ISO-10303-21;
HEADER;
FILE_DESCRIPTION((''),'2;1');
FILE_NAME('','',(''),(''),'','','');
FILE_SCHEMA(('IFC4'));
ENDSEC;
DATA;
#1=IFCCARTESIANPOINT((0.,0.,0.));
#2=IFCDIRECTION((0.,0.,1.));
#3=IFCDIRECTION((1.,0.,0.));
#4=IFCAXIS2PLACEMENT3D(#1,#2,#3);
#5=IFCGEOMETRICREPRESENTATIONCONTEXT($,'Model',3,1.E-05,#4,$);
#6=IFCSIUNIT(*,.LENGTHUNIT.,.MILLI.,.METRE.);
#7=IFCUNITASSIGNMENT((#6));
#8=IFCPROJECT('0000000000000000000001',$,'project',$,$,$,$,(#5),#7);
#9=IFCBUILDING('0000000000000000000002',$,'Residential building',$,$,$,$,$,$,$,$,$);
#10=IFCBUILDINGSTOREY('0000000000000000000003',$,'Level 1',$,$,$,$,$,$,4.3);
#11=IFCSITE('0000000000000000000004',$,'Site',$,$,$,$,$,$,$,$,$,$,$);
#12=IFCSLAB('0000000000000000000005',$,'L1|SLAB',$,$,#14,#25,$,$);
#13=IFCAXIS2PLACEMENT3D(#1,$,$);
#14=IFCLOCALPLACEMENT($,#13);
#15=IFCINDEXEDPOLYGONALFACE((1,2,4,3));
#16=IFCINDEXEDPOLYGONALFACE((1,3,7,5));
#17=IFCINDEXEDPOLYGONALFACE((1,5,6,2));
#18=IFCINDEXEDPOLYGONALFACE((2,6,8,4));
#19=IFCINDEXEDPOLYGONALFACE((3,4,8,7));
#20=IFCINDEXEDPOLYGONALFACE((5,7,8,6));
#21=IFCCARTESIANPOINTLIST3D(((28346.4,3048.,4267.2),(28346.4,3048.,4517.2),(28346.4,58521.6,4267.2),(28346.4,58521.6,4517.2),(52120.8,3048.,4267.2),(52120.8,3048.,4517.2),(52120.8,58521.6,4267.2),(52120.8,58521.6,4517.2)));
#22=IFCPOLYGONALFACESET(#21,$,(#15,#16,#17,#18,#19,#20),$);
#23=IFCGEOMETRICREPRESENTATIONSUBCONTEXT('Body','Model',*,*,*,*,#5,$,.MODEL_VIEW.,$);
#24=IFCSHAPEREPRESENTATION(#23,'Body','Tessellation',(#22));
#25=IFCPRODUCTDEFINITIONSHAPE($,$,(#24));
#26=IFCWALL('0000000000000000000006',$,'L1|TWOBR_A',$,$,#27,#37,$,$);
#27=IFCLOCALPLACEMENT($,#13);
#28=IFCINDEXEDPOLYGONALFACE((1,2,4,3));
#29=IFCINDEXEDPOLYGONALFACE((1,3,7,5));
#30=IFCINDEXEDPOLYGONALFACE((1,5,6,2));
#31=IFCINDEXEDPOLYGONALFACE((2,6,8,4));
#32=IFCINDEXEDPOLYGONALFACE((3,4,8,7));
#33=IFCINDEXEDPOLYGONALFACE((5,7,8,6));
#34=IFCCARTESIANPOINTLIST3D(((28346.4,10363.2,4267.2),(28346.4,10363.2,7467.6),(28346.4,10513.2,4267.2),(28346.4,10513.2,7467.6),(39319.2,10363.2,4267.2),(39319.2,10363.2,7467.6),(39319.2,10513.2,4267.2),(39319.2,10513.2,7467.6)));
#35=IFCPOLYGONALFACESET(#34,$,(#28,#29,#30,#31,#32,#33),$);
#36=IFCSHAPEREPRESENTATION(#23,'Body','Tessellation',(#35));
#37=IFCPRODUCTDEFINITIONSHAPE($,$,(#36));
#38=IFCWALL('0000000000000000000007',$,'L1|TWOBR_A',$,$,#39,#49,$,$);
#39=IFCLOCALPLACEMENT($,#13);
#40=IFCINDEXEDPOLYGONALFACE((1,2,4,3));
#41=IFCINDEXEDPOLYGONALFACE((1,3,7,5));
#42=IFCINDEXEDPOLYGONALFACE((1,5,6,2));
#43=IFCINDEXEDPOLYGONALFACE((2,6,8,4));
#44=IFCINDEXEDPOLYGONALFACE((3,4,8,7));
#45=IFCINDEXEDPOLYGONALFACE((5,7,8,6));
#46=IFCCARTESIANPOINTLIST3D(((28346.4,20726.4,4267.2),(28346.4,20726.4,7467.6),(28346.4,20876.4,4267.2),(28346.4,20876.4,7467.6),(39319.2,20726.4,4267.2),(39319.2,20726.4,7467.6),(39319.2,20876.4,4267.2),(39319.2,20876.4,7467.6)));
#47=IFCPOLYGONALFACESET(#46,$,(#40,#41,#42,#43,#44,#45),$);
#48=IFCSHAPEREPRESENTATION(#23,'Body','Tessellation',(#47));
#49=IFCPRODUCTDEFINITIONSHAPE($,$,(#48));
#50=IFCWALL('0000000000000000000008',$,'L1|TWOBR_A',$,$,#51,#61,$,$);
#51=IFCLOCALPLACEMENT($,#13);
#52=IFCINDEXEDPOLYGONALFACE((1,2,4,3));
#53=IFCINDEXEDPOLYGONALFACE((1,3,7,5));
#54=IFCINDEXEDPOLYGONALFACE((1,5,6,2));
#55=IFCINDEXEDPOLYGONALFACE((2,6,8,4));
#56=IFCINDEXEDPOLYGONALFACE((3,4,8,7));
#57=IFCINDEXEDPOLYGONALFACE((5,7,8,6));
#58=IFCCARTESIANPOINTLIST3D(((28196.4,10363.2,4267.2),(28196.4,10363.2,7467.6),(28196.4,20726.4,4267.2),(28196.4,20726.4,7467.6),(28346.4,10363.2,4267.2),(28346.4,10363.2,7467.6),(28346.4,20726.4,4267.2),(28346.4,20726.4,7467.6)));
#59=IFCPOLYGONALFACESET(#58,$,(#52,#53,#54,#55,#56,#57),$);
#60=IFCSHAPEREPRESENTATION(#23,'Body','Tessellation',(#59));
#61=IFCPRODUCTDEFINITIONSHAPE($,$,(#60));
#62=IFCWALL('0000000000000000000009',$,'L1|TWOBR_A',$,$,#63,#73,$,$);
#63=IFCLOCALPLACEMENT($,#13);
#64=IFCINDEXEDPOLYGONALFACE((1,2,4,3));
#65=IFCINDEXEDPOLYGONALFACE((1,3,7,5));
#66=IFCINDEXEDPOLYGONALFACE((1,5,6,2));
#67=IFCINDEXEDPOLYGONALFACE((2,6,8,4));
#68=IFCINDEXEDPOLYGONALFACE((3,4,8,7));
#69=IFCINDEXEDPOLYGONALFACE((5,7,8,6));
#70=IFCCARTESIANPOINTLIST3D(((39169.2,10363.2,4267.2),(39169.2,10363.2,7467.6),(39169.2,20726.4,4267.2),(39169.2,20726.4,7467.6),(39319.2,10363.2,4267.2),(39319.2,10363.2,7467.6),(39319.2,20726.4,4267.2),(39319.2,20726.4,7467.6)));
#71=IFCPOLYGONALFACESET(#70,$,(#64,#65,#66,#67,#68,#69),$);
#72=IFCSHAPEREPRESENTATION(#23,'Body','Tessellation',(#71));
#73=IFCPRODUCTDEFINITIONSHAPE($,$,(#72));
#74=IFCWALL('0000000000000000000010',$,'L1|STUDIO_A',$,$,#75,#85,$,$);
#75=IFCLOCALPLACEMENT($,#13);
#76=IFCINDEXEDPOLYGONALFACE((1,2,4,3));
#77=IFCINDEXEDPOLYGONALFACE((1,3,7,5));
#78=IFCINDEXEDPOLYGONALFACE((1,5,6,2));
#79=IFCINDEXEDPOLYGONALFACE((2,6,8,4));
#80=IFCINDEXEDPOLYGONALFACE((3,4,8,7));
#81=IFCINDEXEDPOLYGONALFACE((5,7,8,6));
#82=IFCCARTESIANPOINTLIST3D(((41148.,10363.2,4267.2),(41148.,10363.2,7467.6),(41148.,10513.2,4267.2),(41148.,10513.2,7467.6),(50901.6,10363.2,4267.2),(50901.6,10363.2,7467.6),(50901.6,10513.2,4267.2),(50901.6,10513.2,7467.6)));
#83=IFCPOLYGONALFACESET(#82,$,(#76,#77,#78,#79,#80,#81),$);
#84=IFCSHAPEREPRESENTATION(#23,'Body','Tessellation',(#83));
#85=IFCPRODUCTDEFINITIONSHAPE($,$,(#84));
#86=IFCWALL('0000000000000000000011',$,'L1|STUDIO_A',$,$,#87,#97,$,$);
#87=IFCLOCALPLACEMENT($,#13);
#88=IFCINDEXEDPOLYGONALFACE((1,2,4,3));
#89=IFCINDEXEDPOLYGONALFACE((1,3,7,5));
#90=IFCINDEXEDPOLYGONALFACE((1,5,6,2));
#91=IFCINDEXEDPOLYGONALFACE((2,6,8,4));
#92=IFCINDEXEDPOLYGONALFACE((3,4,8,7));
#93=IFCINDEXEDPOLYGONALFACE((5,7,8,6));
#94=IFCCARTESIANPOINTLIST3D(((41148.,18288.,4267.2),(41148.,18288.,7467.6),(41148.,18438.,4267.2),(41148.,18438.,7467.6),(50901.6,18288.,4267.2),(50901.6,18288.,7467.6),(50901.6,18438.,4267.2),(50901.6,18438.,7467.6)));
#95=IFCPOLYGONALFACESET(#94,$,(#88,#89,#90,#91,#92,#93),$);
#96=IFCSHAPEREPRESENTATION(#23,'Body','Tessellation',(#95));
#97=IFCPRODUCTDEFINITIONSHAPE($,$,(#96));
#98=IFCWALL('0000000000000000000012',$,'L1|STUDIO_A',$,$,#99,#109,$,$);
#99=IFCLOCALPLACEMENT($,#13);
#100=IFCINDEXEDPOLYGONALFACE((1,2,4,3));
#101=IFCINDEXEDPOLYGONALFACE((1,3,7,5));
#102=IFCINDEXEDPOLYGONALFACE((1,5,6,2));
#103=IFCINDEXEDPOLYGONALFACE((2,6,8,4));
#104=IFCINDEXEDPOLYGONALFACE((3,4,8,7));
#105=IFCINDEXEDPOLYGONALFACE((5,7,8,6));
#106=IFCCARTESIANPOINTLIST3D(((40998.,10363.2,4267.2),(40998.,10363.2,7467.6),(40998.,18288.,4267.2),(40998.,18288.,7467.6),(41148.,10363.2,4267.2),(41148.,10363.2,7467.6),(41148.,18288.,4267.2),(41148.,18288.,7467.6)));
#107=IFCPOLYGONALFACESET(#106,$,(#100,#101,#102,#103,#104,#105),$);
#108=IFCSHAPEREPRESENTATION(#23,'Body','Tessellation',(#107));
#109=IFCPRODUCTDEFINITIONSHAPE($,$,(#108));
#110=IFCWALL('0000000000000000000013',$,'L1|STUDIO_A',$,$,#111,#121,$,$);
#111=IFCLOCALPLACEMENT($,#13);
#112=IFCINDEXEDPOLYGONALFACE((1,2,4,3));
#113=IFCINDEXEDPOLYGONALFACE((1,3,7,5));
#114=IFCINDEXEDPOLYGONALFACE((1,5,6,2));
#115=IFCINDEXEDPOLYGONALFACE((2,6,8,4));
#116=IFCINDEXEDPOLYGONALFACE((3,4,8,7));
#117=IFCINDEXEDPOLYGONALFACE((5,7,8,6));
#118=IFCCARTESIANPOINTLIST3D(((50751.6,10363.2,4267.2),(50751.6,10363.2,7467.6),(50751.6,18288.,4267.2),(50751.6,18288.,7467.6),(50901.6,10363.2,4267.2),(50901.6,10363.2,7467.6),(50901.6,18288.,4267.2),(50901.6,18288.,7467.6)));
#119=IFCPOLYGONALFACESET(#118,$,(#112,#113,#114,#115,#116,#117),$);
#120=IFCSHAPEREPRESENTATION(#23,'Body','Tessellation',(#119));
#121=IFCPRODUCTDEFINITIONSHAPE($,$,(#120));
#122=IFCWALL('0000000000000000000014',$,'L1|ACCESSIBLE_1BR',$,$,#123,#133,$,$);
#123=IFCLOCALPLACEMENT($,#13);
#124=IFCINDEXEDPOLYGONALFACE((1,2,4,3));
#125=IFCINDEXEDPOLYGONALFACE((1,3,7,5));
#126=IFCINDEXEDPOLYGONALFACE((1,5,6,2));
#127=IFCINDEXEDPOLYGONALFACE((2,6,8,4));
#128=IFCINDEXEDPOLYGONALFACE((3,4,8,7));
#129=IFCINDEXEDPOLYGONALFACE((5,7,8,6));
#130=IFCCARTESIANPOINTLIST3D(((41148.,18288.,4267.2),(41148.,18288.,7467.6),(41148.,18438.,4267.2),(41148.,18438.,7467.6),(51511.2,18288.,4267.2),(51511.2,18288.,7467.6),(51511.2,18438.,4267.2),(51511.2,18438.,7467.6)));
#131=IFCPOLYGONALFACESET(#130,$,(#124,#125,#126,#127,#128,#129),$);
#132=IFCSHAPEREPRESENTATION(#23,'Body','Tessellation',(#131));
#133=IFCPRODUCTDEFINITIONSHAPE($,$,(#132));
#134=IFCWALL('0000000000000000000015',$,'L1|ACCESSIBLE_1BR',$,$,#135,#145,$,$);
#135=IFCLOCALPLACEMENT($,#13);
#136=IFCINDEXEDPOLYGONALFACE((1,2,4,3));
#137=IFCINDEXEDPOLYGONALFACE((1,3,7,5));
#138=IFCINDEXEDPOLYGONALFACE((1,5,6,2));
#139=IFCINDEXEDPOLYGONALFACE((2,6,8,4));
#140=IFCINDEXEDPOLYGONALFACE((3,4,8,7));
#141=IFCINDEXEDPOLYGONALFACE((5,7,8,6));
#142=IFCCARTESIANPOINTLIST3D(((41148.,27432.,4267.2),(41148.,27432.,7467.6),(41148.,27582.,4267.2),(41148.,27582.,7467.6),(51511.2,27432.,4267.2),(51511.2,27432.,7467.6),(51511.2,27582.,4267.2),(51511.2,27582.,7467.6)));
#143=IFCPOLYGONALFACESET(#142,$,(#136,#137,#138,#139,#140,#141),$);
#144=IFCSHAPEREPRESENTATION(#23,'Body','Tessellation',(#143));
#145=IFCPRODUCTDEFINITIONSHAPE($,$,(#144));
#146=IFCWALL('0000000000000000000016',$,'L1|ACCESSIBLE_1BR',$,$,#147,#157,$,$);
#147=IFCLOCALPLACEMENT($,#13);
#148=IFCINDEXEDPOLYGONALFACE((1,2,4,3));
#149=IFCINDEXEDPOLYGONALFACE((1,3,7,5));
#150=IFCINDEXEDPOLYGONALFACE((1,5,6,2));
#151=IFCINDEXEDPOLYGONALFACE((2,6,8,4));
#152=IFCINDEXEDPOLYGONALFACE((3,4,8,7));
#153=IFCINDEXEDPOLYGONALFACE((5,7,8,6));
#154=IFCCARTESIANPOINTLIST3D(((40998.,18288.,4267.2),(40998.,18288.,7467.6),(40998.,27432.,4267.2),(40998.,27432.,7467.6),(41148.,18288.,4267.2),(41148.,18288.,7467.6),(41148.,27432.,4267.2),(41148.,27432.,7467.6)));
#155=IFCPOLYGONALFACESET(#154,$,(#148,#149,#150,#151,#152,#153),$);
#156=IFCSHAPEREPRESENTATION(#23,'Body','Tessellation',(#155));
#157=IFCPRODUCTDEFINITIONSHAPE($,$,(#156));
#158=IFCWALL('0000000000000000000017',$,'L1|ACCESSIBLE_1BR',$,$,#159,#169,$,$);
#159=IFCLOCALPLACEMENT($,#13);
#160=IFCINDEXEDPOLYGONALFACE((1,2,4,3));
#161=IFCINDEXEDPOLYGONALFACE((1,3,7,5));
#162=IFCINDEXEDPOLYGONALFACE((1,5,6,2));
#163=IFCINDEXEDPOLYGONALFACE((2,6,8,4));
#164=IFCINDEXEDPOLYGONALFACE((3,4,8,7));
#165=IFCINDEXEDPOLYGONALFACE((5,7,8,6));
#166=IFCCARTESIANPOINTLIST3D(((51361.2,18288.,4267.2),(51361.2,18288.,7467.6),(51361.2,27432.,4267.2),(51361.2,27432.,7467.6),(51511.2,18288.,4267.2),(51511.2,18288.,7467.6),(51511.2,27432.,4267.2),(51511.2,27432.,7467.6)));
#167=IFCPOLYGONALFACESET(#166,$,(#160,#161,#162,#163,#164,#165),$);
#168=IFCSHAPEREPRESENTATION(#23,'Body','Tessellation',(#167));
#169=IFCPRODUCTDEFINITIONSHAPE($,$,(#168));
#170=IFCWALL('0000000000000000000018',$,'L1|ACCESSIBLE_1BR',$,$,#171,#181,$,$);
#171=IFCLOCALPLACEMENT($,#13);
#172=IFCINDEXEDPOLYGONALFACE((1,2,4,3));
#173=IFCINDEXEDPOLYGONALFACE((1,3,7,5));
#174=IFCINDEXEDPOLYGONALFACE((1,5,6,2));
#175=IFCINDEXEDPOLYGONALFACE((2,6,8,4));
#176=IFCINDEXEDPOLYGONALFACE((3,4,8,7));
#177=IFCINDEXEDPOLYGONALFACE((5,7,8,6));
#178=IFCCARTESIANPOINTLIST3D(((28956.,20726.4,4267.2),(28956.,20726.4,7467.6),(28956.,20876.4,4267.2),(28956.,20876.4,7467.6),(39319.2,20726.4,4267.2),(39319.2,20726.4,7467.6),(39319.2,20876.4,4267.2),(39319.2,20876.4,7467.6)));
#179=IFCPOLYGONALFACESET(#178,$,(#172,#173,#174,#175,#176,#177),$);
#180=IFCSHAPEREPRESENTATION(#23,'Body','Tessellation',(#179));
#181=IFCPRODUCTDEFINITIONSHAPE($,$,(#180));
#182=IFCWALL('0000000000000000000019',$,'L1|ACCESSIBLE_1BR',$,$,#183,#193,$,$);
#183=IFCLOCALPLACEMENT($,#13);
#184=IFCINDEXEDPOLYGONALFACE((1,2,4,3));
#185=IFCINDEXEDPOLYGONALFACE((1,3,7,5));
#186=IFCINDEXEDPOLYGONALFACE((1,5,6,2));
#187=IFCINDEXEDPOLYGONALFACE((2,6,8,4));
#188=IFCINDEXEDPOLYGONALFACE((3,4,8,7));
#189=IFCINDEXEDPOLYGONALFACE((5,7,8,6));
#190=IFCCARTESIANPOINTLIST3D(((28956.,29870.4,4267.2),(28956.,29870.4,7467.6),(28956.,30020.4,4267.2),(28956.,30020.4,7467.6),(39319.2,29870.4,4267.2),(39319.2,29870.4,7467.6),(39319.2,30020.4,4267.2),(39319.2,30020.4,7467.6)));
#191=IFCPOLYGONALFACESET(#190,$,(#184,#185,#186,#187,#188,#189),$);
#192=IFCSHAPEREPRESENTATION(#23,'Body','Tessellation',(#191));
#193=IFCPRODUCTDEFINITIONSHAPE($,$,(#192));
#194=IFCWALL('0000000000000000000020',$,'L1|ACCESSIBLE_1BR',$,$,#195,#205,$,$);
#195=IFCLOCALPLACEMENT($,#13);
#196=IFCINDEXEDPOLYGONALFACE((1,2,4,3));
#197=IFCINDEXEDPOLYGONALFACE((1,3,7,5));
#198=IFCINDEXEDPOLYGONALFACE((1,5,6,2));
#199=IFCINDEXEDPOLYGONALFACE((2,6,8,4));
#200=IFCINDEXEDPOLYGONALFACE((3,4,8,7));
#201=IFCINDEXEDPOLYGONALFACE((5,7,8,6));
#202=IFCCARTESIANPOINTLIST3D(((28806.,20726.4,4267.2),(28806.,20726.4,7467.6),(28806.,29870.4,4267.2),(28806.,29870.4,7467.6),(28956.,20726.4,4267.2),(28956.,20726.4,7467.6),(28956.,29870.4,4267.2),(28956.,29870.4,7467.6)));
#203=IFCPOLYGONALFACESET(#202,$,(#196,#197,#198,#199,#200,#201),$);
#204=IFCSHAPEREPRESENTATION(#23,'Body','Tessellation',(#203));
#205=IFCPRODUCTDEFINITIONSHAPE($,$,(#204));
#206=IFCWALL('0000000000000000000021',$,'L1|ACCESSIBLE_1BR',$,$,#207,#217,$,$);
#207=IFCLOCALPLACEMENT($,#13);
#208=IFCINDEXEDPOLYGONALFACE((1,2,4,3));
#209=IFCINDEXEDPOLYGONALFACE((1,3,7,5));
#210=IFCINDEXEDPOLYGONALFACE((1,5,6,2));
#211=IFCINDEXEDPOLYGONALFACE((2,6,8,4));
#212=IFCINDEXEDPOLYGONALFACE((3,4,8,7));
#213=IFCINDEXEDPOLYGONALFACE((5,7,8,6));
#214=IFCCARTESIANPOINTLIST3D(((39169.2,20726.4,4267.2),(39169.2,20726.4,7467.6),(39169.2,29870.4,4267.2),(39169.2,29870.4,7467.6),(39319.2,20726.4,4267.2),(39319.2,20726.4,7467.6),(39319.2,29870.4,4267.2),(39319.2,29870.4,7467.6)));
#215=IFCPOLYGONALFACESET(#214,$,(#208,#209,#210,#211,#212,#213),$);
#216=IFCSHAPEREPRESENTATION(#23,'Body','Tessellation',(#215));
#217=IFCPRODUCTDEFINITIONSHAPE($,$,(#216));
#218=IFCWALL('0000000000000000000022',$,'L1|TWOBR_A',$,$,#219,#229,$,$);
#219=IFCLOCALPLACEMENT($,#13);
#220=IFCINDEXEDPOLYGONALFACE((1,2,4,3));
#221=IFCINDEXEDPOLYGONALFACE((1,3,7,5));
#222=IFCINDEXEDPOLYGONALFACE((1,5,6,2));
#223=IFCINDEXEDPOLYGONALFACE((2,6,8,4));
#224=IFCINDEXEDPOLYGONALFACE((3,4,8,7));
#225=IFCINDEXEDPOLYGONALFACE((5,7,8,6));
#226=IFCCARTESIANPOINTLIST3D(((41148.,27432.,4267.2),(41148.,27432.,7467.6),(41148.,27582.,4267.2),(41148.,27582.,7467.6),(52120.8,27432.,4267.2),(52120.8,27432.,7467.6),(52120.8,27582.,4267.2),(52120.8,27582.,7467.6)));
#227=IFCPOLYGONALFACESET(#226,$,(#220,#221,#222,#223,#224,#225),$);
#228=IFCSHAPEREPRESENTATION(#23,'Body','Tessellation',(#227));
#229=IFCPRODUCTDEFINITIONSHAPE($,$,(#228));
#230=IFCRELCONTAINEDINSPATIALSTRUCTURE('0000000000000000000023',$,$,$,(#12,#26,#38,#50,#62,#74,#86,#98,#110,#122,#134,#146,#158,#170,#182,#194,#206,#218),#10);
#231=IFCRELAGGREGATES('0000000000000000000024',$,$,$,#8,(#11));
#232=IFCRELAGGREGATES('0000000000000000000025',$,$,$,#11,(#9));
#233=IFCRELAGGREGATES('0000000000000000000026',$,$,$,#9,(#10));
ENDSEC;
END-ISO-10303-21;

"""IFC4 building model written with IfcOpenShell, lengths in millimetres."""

from ifc_helpers import new_model, si_unit, frame, origin_with_axes, place, context, subcontext, project, spatial, indexed_curve, outline, extrude, element, save


model = new_model("IFC4")

# Units and contexts
model_context = context("Model", 3, precision=1e-05, world=origin_with_axes())
body_context = subcontext(model_context, "Body", "Model", "MODEL_VIEW")
ifc_project = project(units=[si_unit("LENGTHUNIT", "METRE", prefix="MILLI")], contexts=[model_context])

# Site, building, storey
site = spatial("IfcSite", under=ifc_project, Name="Site")
building = spatial("IfcBuilding", under=site, Name="Residential building")
storey = spatial("IfcBuildingStorey", under=building, Name="Level 1", Elevation=4.3)

# Slab
slab_placement = place(None, frame((28346.4, 3048.0, 4267.2), z_axis=(0.0, 0.0, 1.0), x_axis=(1.0, 0.0, 0.0)))
element("IfcSlab", 1, at=slab_placement, inside=storey, Name="L1|SLAB", context=body_context, shape_type="SweptSolid", body=[
    extrude(outline(indexed_curve([(0.0, 0.0), (23774.4, 0.0), (23774.4, 55473.6), (0.0, 55473.6), (0.0, 0.0)])), None, (0.0, 0.0, 1.0), 250.0),
])

# Walls
for number, where, z_axis, x_axis, name in (
    (2, (28346.4, 10363.2, 4267.2), (0.0, 0.0, 1.0), (1.0, 0.0, 0.0), "L1|TWOBR_A"),
    (3, (28346.4, 20726.4, 4267.2), (0.0, 0.0, 1.0), (1.0, 0.0, 0.0), "L1|TWOBR_A"),
):
    element("IfcWall", number, at=place(None, frame(where, z_axis=z_axis, x_axis=x_axis)), inside=storey, Name=name, context=body_context, shape_type="SweptSolid", body=[
        extrude(outline(indexed_curve([(0.0, 0.0), (0.0, 150.0), (10972.8, 150.0), (10972.8, 0.0), (0.0, 0.0)], self_intersect=False)), origin_with_axes(), (0.0, 0.0, 1.0), 3200.4),
    ])
for number, where, z_axis, x_axis, name in (
    (4, (28346.4, 10363.2, 4267.2), (0.0, 0.0, 1.0), (0.0, 1.0, 0.0), "L1|TWOBR_A"),
    (5, (39319.2, 10363.2, 4267.2), (0.0, 0.0, 1.0), (0.0, 1.0, 0.0), "L1|TWOBR_A"),
):
    element("IfcWall", number, at=place(None, frame(where, z_axis=z_axis, x_axis=x_axis)), inside=storey, Name=name, context=body_context, shape_type="SweptSolid", body=[
        extrude(outline(indexed_curve([(0.0, 0.0), (0.0, 150.0), (10363.2, 150.0), (10363.2, 0.0), (0.0, 0.0)], self_intersect=False)), origin_with_axes(), (0.0, 0.0, 1.0), 3200.4),
    ])
for number, where, z_axis, x_axis, name in (
    (6, (41148.0, 10363.2, 4267.2), (0.0, 0.0, 1.0), (1.0, 0.0, 0.0), "L1|STUDIO_A"),
    (7, (41148.0, 18288.0, 4267.2), (0.0, 0.0, 1.0), (1.0, 0.0, 0.0), "L1|STUDIO_A"),
):
    element("IfcWall", number, at=place(None, frame(where, z_axis=z_axis, x_axis=x_axis)), inside=storey, Name=name, context=body_context, shape_type="SweptSolid", body=[
        extrude(outline(indexed_curve([(0.0, 0.0), (0.0, 150.0), (9753.6, 150.0), (9753.6, 0.0), (0.0, 0.0)], self_intersect=False)), origin_with_axes(), (0.0, 0.0, 1.0), 3200.4),
    ])
for number, where, z_axis, x_axis, name in (
    (8, (41148.0, 10363.2, 4267.2), (0.0, 0.0, 1.0), (0.0, 1.0, 0.0), "L1|STUDIO_A"),
    (9, (50901.6, 10363.2, 4267.2), (0.0, 0.0, 1.0), (0.0, 1.0, 0.0), "L1|STUDIO_A"),
):
    element("IfcWall", number, at=place(None, frame(where, z_axis=z_axis, x_axis=x_axis)), inside=storey, Name=name, context=body_context, shape_type="SweptSolid", body=[
        extrude(outline(indexed_curve([(0.0, 0.0), (0.0, 150.0), (7924.8, 150.0), (7924.8, 0.0), (0.0, 0.0)], self_intersect=False)), origin_with_axes(), (0.0, 0.0, 1.0), 3200.4),
    ])
for number, where, z_axis, x_axis, name in (
    (10, (41148.0, 18288.0, 4267.2), (0.0, 0.0, 1.0), (1.0, 0.0, 0.0), "L1|ACCESSIBLE_1BR"),
    (11, (41148.0, 27432.0, 4267.2), (0.0, 0.0, 1.0), (1.0, 0.0, 0.0), "L1|ACCESSIBLE_1BR"),
):
    element("IfcWall", number, at=place(None, frame(where, z_axis=z_axis, x_axis=x_axis)), inside=storey, Name=name, context=body_context, shape_type="SweptSolid", body=[
        extrude(outline(indexed_curve([(0.0, 0.0), (0.0, 150.0), (10363.2, 150.0), (10363.2, 0.0), (0.0, 0.0)], self_intersect=False)), origin_with_axes(), (0.0, 0.0, 1.0), 3200.4),
    ])
for number, where, z_axis, x_axis, name in (
    (12, (41148.0, 18288.0, 4267.2), (0.0, 0.0, 1.0), (0.0, 1.0, 0.0), "L1|ACCESSIBLE_1BR"),
    (13, (51511.2, 18288.0, 4267.2), (0.0, 0.0, 1.0), (0.0, 1.0, 0.0), "L1|ACCESSIBLE_1BR"),
):
    element("IfcWall", number, at=place(None, frame(where, z_axis=z_axis, x_axis=x_axis)), inside=storey, Name=name, context=body_context, shape_type="SweptSolid", body=[
        extrude(outline(indexed_curve([(0.0, 0.0), (0.0, 150.0), (9144.0, 150.0), (9144.0, 0.0), (0.0, 0.0)], self_intersect=False)), origin_with_axes(), (0.0, 0.0, 1.0), 3200.4),
    ])
for number, where, z_axis, x_axis, name in (
    (14, (28956.0, 20726.4, 4267.2), (0.0, 0.0, 1.0), (1.0, 0.0, 0.0), "L1|ACCESSIBLE_1BR"),
    (15, (28956.0, 29870.4, 4267.2), (0.0, 0.0, 1.0), (1.0, 0.0, 0.0), "L1|ACCESSIBLE_1BR"),
):
    element("IfcWall", number, at=place(None, frame(where, z_axis=z_axis, x_axis=x_axis)), inside=storey, Name=name, context=body_context, shape_type="SweptSolid", body=[
        extrude(outline(indexed_curve([(0.0, 0.0), (0.0, 150.0), (10363.2, 150.0), (10363.2, 0.0), (0.0, 0.0)], self_intersect=False)), origin_with_axes(), (0.0, 0.0, 1.0), 3200.4),
    ])
for number, where, z_axis, x_axis, name in (
    (16, (28956.0, 20726.4, 4267.2), (0.0, 0.0, 1.0), (0.0, 1.0, 0.0), "L1|ACCESSIBLE_1BR"),
    (17, (39319.2, 20726.4, 4267.2), (0.0, 0.0, 1.0), (0.0, 1.0, 0.0), "L1|ACCESSIBLE_1BR"),
):
    element("IfcWall", number, at=place(None, frame(where, z_axis=z_axis, x_axis=x_axis)), inside=storey, Name=name, context=body_context, shape_type="SweptSolid", body=[
        extrude(outline(indexed_curve([(0.0, 0.0), (0.0, 150.0), (9144.0, 150.0), (9144.0, 0.0), (0.0, 0.0)], self_intersect=False)), origin_with_axes(), (0.0, 0.0, 1.0), 3200.4),
    ])
wall_placement = place(None, frame((41148.0, 27432.0, 4267.2), z_axis=(0.0, 0.0, 1.0), x_axis=(1.0, 0.0, 0.0)))
element("IfcWall", 18, at=wall_placement, inside=storey, Name="L1|TWOBR_A", context=body_context, shape_type="SweptSolid", body=[
    extrude(outline(indexed_curve([(0.0, 0.0), (0.0, 150.0), (10972.8, 150.0), (10972.8, 0.0), (0.0, 0.0)], self_intersect=False)), origin_with_axes(), (0.0, 0.0, 1.0), 3200.4),
])

save(model, "model.ifc")
